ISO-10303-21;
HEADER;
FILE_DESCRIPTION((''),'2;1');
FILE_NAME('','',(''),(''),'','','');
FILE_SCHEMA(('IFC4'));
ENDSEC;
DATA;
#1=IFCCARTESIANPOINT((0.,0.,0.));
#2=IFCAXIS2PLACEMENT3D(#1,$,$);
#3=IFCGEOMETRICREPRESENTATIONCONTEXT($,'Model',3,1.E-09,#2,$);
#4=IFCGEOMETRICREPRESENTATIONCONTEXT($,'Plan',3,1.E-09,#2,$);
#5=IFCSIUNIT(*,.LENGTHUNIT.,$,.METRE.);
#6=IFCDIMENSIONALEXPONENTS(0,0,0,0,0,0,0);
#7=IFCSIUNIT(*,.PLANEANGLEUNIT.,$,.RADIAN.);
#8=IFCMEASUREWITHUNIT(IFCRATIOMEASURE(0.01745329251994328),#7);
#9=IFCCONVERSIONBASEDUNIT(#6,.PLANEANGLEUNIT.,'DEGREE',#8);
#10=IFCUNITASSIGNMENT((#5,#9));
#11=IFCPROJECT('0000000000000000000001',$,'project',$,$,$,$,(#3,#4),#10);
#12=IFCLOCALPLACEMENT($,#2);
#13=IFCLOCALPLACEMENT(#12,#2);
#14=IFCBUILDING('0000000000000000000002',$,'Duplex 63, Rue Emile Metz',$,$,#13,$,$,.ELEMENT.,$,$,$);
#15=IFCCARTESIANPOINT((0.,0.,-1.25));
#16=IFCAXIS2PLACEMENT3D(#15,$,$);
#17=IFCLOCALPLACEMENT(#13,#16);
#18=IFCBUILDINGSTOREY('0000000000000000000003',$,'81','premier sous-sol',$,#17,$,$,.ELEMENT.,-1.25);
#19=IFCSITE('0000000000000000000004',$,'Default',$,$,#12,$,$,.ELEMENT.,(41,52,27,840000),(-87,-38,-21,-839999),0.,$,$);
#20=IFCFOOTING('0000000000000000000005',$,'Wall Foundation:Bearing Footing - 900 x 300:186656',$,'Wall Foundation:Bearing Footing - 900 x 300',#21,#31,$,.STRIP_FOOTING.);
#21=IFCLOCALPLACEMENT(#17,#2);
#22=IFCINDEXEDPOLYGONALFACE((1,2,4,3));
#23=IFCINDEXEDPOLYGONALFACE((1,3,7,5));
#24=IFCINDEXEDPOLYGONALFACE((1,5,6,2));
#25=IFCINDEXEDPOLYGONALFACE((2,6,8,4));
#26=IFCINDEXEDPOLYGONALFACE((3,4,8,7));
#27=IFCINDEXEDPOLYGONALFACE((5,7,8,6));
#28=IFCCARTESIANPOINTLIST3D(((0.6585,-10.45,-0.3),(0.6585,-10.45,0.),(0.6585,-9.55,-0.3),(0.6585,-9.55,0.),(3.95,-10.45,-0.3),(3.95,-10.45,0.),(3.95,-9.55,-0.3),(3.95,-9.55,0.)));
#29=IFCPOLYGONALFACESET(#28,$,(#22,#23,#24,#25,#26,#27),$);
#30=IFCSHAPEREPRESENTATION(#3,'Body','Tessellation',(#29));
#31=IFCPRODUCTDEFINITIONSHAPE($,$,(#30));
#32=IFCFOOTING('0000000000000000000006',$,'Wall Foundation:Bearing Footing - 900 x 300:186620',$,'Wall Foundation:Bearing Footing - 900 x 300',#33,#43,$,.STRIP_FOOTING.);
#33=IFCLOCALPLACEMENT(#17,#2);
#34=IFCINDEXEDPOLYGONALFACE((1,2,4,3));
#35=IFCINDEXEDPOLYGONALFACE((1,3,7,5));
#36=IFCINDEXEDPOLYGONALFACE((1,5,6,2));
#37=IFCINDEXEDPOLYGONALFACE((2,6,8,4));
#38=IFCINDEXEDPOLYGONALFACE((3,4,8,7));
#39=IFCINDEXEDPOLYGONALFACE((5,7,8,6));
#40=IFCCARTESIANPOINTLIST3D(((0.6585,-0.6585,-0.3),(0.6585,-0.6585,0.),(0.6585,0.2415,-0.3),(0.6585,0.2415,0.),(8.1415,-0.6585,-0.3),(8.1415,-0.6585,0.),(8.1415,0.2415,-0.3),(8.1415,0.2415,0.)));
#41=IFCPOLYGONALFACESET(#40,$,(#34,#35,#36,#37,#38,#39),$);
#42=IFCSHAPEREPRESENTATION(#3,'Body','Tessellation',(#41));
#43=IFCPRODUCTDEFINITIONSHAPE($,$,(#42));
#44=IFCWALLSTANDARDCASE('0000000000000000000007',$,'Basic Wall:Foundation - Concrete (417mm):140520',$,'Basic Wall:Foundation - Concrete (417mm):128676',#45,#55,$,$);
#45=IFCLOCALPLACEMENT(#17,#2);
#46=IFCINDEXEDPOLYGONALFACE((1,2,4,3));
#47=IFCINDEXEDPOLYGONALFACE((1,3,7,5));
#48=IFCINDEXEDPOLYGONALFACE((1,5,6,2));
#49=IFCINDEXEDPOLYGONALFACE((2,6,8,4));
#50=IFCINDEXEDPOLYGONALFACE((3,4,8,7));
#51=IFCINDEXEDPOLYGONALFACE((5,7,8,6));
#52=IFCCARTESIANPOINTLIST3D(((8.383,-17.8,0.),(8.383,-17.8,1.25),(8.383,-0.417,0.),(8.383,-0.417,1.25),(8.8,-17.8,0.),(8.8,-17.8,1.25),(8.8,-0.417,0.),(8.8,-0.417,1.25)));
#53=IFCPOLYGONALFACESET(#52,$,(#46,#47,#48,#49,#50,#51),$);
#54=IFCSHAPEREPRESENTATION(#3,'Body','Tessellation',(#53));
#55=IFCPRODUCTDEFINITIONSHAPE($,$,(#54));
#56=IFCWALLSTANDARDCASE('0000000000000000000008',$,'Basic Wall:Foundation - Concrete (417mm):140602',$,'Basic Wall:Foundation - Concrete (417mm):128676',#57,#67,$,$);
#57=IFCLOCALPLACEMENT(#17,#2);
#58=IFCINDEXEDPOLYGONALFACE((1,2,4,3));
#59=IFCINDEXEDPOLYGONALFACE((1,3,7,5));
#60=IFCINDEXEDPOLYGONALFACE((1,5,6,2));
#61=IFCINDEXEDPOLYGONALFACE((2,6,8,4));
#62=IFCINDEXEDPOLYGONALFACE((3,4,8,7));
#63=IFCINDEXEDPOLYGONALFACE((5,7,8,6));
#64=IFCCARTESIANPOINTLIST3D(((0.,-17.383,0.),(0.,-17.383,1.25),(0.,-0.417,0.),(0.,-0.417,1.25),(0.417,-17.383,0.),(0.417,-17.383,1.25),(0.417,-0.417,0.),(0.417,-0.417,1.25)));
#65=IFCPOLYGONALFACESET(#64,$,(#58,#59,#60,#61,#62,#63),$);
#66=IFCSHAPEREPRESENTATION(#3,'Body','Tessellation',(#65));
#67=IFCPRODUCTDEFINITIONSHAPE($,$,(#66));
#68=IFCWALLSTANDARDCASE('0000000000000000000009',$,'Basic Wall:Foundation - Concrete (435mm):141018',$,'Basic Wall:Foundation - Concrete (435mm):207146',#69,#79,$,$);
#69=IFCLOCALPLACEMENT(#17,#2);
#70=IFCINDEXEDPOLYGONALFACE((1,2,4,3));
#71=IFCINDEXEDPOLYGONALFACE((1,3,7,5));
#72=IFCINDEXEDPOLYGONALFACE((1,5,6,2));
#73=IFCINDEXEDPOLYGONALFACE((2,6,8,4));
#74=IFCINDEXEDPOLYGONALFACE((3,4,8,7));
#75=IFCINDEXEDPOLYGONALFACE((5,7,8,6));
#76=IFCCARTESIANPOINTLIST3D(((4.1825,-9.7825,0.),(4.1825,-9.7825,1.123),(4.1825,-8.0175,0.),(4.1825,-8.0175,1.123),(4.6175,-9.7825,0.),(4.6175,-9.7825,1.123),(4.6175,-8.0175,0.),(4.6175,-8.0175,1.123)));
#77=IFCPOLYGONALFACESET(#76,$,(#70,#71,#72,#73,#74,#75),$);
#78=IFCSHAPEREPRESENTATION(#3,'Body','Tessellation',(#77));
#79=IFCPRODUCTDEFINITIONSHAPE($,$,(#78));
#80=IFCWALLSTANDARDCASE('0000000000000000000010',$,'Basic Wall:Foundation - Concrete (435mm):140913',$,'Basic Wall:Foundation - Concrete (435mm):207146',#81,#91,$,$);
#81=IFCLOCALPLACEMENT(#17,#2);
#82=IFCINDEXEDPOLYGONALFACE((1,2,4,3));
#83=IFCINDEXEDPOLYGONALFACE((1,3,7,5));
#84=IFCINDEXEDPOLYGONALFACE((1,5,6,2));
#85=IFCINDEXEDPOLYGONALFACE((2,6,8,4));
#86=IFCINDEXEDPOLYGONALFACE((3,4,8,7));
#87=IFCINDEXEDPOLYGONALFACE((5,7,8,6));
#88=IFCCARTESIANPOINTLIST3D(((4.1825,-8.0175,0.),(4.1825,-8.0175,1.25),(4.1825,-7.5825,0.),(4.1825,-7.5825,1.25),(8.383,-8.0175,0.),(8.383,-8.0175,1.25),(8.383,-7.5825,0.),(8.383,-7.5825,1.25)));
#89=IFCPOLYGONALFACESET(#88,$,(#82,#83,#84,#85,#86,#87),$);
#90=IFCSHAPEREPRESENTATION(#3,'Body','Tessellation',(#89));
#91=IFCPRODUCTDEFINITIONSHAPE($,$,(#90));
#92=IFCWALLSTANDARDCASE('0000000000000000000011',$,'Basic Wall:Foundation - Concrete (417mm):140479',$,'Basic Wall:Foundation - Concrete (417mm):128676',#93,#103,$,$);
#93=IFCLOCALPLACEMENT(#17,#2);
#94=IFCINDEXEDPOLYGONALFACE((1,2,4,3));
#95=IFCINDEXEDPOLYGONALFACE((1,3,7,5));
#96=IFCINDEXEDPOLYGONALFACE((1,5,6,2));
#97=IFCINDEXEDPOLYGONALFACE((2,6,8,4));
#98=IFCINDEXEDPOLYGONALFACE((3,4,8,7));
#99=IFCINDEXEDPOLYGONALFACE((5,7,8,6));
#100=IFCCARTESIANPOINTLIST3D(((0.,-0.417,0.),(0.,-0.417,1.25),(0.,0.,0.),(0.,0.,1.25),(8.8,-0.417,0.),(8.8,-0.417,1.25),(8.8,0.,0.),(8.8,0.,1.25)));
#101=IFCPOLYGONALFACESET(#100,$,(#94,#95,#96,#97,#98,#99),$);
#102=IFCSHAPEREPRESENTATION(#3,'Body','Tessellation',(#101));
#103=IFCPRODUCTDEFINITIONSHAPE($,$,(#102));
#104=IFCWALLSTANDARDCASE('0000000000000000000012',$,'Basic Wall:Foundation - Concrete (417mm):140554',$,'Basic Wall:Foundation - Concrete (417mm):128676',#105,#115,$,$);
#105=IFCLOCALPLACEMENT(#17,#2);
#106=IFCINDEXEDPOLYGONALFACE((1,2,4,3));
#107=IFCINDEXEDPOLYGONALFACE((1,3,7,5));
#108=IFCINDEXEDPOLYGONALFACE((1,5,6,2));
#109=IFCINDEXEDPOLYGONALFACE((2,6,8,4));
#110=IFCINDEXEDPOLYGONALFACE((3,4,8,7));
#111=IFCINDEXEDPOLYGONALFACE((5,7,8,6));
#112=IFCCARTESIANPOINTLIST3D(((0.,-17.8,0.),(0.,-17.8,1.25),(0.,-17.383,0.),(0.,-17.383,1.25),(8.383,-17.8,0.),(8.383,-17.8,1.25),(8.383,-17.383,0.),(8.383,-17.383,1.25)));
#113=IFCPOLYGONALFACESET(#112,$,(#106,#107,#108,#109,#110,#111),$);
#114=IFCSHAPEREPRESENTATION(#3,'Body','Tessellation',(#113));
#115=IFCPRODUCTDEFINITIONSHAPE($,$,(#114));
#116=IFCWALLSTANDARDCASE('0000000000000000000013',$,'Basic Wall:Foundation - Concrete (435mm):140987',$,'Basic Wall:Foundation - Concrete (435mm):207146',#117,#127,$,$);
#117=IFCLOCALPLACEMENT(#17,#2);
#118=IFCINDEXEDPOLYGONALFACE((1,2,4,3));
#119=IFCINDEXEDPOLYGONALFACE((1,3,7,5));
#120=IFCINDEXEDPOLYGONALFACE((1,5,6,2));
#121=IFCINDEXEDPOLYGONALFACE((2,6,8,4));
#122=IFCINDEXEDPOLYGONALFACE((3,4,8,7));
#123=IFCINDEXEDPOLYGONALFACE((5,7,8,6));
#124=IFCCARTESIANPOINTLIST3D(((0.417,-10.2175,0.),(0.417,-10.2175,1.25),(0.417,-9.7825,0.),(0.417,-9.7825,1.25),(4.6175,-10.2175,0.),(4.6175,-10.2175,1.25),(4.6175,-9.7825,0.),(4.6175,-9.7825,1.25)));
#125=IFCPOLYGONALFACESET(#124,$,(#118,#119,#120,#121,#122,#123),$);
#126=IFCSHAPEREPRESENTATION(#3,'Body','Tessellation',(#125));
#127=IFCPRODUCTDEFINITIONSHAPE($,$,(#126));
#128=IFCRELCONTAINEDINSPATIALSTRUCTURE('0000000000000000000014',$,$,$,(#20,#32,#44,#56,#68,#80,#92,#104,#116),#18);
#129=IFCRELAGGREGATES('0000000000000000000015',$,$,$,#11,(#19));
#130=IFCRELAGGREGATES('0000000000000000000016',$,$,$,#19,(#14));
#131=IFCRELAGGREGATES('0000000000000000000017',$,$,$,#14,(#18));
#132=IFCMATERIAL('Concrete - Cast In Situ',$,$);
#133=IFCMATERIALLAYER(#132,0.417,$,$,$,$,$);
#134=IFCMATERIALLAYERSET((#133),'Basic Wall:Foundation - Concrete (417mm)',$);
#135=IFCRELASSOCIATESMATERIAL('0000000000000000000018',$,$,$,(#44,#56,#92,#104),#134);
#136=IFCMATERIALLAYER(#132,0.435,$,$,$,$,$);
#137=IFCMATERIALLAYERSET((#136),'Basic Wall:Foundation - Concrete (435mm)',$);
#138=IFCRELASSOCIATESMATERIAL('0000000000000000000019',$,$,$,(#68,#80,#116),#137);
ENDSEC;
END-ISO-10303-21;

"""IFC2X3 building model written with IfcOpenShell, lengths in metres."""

from ifc_helpers import new_model, entity, si_unit, converted_unit, frame, frame_2d, origin, origin_2d_with_axis, place, context, project, spatial, rectangle, extrude, material, layer, layer_set, layer_usage, element, save


model = new_model("IFC2X3")

# Units and contexts
model_context = context("Model", 3, precision=1e-09, world=origin())
plan_context = context("Plan", 3, precision=1e-09, world=origin())
ifc_project = project(units=[si_unit("LENGTHUNIT", "METRE"), converted_unit("PLANEANGLEUNIT", "DEGREE", entity("IfcRatioMeasure", 0.01745329251994328), si_unit("PLANEANGLEUNIT", "RADIAN"), dimensions=[0, 0, 0, 0, 0, 0, 0])], contexts=[model_context, plan_context])

# Site, building, storey
site_placement = place(None, origin())
site = spatial("IfcSite", under=ifc_project, at=site_placement, Name="Default", CompositionType="ELEMENT", RefLatitude=(41, 52, 27, 840000), RefLongitude=(-87, -38, -21, -839999), RefElevation=0.0)
building_placement = place(site_placement, origin())
building = spatial("IfcBuilding", under=site, at=building_placement, Name="Duplex 63, Rue Emile Metz", CompositionType="ELEMENT")
storey_placement = place(building_placement, frame((0.0, 0.0, -1.25)))
storey = spatial("IfcBuildingStorey", under=building, at=storey_placement, Name="81", Description="premier sous-sol", CompositionType="ELEMENT", Elevation=-1.25)

# Footings
footing_1_placement = place(storey_placement, origin())
element("IfcFooting", 1, at=footing_1_placement, inside=storey, Name="Wall Foundation:Bearing Footing - 900 x 300:186656", ObjectType="Wall Foundation:Bearing Footing - 900 x 300", PredefinedType="STRIP_FOOTING", context=model_context, shape_type="SweptSolid", body=[
    extrude(rectangle(XDim=3.2915, YDim=0.9, at=origin_2d_with_axis()), frame((2.3042, -10.0, -0.3)), (0.0, 0.0, 1.0), 0.3),
])
footing_2_placement = place(storey_placement, origin())
element("IfcFooting", 2, at=footing_2_placement, inside=storey, Name="Wall Foundation:Bearing Footing - 900 x 300:186620", ObjectType="Wall Foundation:Bearing Footing - 900 x 300", PredefinedType="STRIP_FOOTING", context=model_context, shape_type="SweptSolid", body=[
    extrude(rectangle(XDim=7.483, YDim=0.9, at=origin_2d_with_axis()), frame((4.4, -0.2085, -0.3), z_axis=(0.0, 0.0, 1.0), x_axis=(-1.0, 0.0, 0.0)), (0.0, 0.0, 1.0), 0.3),
])

# Walls
ifc_material = material(Name="Concrete - Cast In Situ")
ifc_layer_1 = layer(ifc_material, 0.417)
ifc_layer_set_1 = layer_set([ifc_layer_1], Name="Basic Wall:Foundation - Concrete (417mm)")
ifc_layer_usage_1 = layer_usage(ifc_layer_set_1, "AXIS2", "NEGATIVE", 0.2085)
wall_1_placement = place(storey_placement, frame((8.5915, -0.417, 0.0), z_axis=(0.0, 0.0, 1.0), x_axis=(0.0, -1.0, 0.0)))
element("IfcWallStandardCase", 3, at=wall_1_placement, inside=storey, material=ifc_layer_usage_1, Name="Basic Wall:Foundation - Concrete (417mm):140520", ObjectType="Basic Wall:Foundation - Concrete (417mm):128676", context=model_context, shape_type="SweptSolid", body=[
    extrude(rectangle(XDim=17.383, YDim=0.417, at=frame_2d((8.6915, 0.0), x_axis=(-1.0, 0.0))), origin(), (0.0, 0.0, 1.0), 1.25),
])
wall_2_placement = place(storey_placement, frame((0.2085, -17.383, 0.0), z_axis=(0.0, 0.0, 1.0), x_axis=(0.0, 1.0, 0.0)))
element("IfcWallStandardCase", 4, at=wall_2_placement, inside=storey, material=ifc_layer_usage_1, Name="Basic Wall:Foundation - Concrete (417mm):140602", ObjectType="Basic Wall:Foundation - Concrete (417mm):128676", context=model_context, shape_type="SweptSolid", body=[
    extrude(rectangle(XDim=16.966, YDim=0.417, at=frame_2d((8.483, 0.0), x_axis=(-1.0, 0.0))), origin(), (0.0, 0.0, 1.0), 1.25),
])
ifc_layer_2 = layer(ifc_material, 0.435)
ifc_layer_set_2 = layer_set([ifc_layer_2], Name="Basic Wall:Foundation - Concrete (435mm)")
ifc_layer_usage_2 = layer_usage(ifc_layer_set_2, "AXIS2", "NEGATIVE", 0.2175)
wall_3_placement = place(storey_placement, frame((4.4, -9.7825, 0.0), z_axis=(0.0, 0.0, 1.0), x_axis=(0.0, 1.0, 0.0)))
element("IfcWallStandardCase", 5, at=wall_3_placement, inside=storey, material=ifc_layer_usage_2, Name="Basic Wall:Foundation - Concrete (435mm):141018", ObjectType="Basic Wall:Foundation - Concrete (435mm):207146", context=model_context, shape_type="SweptSolid", body=[
    extrude(rectangle(XDim=1.765, YDim=0.435, at=frame_2d((0.8825, 0.0), x_axis=(-1.0, 0.0))), origin(), (0.0, 0.0, 1.0), 1.123),
])
wall_4_placement = place(storey_placement, frame((8.383, -7.8, 0.0), z_axis=(0.0, 0.0, 1.0), x_axis=(-1.0, 0.0, 0.0)))
element("IfcWallStandardCase", 6, at=wall_4_placement, inside=storey, material=ifc_layer_usage_2, Name="Basic Wall:Foundation - Concrete (435mm):140913", ObjectType="Basic Wall:Foundation - Concrete (435mm):207146", context=model_context, shape_type="SweptSolid", body=[
    extrude(rectangle(XDim=4.2005, YDim=0.435, at=frame_2d((2.1002, 0.0), x_axis=(-1.0, 0.0))), origin(), (0.0, 0.0, 1.0), 1.25),
])
wall_5_placement = place(storey_placement, frame((0.0, -0.2085, 0.0)))
element("IfcWallStandardCase", 7, at=wall_5_placement, inside=storey, material=ifc_layer_usage_1, Name="Basic Wall:Foundation - Concrete (417mm):140479", ObjectType="Basic Wall:Foundation - Concrete (417mm):128676", context=model_context, shape_type="SweptSolid", body=[
    extrude(rectangle(XDim=8.8, YDim=0.417, at=frame_2d((4.4, 0.0), x_axis=(-1.0, 0.0))), origin(), (0.0, 0.0, 1.0), 1.25),
])
wall_6_placement = place(storey_placement, frame((8.383, -17.5915, 0.0), z_axis=(0.0, 0.0, 1.0), x_axis=(-1.0, 0.0, 0.0)))
element("IfcWallStandardCase", 8, at=wall_6_placement, inside=storey, material=ifc_layer_usage_1, Name="Basic Wall:Foundation - Concrete (417mm):140554", ObjectType="Basic Wall:Foundation - Concrete (417mm):128676", context=model_context, shape_type="SweptSolid", body=[
    extrude(rectangle(XDim=8.383, YDim=0.417, at=frame_2d((4.1915, 0.0), x_axis=(-1.0, 0.0))), origin(), (0.0, 0.0, 1.0), 1.25),
])
wall_7_placement = place(storey_placement, frame((0.417, -10.0, 0.0)))
element("IfcWallStandardCase", 9, at=wall_7_placement, inside=storey, material=ifc_layer_usage_2, Name="Basic Wall:Foundation - Concrete (435mm):140987", ObjectType="Basic Wall:Foundation - Concrete (435mm):207146", context=model_context, shape_type="SweptSolid", body=[
    extrude(rectangle(XDim=4.2005, YDim=0.435, at=frame_2d((2.1002, 0.0), x_axis=(-1.0, 0.0))), origin(), (0.0, 0.0, 1.0), 1.25),
])

save(model, "model.ifc")
